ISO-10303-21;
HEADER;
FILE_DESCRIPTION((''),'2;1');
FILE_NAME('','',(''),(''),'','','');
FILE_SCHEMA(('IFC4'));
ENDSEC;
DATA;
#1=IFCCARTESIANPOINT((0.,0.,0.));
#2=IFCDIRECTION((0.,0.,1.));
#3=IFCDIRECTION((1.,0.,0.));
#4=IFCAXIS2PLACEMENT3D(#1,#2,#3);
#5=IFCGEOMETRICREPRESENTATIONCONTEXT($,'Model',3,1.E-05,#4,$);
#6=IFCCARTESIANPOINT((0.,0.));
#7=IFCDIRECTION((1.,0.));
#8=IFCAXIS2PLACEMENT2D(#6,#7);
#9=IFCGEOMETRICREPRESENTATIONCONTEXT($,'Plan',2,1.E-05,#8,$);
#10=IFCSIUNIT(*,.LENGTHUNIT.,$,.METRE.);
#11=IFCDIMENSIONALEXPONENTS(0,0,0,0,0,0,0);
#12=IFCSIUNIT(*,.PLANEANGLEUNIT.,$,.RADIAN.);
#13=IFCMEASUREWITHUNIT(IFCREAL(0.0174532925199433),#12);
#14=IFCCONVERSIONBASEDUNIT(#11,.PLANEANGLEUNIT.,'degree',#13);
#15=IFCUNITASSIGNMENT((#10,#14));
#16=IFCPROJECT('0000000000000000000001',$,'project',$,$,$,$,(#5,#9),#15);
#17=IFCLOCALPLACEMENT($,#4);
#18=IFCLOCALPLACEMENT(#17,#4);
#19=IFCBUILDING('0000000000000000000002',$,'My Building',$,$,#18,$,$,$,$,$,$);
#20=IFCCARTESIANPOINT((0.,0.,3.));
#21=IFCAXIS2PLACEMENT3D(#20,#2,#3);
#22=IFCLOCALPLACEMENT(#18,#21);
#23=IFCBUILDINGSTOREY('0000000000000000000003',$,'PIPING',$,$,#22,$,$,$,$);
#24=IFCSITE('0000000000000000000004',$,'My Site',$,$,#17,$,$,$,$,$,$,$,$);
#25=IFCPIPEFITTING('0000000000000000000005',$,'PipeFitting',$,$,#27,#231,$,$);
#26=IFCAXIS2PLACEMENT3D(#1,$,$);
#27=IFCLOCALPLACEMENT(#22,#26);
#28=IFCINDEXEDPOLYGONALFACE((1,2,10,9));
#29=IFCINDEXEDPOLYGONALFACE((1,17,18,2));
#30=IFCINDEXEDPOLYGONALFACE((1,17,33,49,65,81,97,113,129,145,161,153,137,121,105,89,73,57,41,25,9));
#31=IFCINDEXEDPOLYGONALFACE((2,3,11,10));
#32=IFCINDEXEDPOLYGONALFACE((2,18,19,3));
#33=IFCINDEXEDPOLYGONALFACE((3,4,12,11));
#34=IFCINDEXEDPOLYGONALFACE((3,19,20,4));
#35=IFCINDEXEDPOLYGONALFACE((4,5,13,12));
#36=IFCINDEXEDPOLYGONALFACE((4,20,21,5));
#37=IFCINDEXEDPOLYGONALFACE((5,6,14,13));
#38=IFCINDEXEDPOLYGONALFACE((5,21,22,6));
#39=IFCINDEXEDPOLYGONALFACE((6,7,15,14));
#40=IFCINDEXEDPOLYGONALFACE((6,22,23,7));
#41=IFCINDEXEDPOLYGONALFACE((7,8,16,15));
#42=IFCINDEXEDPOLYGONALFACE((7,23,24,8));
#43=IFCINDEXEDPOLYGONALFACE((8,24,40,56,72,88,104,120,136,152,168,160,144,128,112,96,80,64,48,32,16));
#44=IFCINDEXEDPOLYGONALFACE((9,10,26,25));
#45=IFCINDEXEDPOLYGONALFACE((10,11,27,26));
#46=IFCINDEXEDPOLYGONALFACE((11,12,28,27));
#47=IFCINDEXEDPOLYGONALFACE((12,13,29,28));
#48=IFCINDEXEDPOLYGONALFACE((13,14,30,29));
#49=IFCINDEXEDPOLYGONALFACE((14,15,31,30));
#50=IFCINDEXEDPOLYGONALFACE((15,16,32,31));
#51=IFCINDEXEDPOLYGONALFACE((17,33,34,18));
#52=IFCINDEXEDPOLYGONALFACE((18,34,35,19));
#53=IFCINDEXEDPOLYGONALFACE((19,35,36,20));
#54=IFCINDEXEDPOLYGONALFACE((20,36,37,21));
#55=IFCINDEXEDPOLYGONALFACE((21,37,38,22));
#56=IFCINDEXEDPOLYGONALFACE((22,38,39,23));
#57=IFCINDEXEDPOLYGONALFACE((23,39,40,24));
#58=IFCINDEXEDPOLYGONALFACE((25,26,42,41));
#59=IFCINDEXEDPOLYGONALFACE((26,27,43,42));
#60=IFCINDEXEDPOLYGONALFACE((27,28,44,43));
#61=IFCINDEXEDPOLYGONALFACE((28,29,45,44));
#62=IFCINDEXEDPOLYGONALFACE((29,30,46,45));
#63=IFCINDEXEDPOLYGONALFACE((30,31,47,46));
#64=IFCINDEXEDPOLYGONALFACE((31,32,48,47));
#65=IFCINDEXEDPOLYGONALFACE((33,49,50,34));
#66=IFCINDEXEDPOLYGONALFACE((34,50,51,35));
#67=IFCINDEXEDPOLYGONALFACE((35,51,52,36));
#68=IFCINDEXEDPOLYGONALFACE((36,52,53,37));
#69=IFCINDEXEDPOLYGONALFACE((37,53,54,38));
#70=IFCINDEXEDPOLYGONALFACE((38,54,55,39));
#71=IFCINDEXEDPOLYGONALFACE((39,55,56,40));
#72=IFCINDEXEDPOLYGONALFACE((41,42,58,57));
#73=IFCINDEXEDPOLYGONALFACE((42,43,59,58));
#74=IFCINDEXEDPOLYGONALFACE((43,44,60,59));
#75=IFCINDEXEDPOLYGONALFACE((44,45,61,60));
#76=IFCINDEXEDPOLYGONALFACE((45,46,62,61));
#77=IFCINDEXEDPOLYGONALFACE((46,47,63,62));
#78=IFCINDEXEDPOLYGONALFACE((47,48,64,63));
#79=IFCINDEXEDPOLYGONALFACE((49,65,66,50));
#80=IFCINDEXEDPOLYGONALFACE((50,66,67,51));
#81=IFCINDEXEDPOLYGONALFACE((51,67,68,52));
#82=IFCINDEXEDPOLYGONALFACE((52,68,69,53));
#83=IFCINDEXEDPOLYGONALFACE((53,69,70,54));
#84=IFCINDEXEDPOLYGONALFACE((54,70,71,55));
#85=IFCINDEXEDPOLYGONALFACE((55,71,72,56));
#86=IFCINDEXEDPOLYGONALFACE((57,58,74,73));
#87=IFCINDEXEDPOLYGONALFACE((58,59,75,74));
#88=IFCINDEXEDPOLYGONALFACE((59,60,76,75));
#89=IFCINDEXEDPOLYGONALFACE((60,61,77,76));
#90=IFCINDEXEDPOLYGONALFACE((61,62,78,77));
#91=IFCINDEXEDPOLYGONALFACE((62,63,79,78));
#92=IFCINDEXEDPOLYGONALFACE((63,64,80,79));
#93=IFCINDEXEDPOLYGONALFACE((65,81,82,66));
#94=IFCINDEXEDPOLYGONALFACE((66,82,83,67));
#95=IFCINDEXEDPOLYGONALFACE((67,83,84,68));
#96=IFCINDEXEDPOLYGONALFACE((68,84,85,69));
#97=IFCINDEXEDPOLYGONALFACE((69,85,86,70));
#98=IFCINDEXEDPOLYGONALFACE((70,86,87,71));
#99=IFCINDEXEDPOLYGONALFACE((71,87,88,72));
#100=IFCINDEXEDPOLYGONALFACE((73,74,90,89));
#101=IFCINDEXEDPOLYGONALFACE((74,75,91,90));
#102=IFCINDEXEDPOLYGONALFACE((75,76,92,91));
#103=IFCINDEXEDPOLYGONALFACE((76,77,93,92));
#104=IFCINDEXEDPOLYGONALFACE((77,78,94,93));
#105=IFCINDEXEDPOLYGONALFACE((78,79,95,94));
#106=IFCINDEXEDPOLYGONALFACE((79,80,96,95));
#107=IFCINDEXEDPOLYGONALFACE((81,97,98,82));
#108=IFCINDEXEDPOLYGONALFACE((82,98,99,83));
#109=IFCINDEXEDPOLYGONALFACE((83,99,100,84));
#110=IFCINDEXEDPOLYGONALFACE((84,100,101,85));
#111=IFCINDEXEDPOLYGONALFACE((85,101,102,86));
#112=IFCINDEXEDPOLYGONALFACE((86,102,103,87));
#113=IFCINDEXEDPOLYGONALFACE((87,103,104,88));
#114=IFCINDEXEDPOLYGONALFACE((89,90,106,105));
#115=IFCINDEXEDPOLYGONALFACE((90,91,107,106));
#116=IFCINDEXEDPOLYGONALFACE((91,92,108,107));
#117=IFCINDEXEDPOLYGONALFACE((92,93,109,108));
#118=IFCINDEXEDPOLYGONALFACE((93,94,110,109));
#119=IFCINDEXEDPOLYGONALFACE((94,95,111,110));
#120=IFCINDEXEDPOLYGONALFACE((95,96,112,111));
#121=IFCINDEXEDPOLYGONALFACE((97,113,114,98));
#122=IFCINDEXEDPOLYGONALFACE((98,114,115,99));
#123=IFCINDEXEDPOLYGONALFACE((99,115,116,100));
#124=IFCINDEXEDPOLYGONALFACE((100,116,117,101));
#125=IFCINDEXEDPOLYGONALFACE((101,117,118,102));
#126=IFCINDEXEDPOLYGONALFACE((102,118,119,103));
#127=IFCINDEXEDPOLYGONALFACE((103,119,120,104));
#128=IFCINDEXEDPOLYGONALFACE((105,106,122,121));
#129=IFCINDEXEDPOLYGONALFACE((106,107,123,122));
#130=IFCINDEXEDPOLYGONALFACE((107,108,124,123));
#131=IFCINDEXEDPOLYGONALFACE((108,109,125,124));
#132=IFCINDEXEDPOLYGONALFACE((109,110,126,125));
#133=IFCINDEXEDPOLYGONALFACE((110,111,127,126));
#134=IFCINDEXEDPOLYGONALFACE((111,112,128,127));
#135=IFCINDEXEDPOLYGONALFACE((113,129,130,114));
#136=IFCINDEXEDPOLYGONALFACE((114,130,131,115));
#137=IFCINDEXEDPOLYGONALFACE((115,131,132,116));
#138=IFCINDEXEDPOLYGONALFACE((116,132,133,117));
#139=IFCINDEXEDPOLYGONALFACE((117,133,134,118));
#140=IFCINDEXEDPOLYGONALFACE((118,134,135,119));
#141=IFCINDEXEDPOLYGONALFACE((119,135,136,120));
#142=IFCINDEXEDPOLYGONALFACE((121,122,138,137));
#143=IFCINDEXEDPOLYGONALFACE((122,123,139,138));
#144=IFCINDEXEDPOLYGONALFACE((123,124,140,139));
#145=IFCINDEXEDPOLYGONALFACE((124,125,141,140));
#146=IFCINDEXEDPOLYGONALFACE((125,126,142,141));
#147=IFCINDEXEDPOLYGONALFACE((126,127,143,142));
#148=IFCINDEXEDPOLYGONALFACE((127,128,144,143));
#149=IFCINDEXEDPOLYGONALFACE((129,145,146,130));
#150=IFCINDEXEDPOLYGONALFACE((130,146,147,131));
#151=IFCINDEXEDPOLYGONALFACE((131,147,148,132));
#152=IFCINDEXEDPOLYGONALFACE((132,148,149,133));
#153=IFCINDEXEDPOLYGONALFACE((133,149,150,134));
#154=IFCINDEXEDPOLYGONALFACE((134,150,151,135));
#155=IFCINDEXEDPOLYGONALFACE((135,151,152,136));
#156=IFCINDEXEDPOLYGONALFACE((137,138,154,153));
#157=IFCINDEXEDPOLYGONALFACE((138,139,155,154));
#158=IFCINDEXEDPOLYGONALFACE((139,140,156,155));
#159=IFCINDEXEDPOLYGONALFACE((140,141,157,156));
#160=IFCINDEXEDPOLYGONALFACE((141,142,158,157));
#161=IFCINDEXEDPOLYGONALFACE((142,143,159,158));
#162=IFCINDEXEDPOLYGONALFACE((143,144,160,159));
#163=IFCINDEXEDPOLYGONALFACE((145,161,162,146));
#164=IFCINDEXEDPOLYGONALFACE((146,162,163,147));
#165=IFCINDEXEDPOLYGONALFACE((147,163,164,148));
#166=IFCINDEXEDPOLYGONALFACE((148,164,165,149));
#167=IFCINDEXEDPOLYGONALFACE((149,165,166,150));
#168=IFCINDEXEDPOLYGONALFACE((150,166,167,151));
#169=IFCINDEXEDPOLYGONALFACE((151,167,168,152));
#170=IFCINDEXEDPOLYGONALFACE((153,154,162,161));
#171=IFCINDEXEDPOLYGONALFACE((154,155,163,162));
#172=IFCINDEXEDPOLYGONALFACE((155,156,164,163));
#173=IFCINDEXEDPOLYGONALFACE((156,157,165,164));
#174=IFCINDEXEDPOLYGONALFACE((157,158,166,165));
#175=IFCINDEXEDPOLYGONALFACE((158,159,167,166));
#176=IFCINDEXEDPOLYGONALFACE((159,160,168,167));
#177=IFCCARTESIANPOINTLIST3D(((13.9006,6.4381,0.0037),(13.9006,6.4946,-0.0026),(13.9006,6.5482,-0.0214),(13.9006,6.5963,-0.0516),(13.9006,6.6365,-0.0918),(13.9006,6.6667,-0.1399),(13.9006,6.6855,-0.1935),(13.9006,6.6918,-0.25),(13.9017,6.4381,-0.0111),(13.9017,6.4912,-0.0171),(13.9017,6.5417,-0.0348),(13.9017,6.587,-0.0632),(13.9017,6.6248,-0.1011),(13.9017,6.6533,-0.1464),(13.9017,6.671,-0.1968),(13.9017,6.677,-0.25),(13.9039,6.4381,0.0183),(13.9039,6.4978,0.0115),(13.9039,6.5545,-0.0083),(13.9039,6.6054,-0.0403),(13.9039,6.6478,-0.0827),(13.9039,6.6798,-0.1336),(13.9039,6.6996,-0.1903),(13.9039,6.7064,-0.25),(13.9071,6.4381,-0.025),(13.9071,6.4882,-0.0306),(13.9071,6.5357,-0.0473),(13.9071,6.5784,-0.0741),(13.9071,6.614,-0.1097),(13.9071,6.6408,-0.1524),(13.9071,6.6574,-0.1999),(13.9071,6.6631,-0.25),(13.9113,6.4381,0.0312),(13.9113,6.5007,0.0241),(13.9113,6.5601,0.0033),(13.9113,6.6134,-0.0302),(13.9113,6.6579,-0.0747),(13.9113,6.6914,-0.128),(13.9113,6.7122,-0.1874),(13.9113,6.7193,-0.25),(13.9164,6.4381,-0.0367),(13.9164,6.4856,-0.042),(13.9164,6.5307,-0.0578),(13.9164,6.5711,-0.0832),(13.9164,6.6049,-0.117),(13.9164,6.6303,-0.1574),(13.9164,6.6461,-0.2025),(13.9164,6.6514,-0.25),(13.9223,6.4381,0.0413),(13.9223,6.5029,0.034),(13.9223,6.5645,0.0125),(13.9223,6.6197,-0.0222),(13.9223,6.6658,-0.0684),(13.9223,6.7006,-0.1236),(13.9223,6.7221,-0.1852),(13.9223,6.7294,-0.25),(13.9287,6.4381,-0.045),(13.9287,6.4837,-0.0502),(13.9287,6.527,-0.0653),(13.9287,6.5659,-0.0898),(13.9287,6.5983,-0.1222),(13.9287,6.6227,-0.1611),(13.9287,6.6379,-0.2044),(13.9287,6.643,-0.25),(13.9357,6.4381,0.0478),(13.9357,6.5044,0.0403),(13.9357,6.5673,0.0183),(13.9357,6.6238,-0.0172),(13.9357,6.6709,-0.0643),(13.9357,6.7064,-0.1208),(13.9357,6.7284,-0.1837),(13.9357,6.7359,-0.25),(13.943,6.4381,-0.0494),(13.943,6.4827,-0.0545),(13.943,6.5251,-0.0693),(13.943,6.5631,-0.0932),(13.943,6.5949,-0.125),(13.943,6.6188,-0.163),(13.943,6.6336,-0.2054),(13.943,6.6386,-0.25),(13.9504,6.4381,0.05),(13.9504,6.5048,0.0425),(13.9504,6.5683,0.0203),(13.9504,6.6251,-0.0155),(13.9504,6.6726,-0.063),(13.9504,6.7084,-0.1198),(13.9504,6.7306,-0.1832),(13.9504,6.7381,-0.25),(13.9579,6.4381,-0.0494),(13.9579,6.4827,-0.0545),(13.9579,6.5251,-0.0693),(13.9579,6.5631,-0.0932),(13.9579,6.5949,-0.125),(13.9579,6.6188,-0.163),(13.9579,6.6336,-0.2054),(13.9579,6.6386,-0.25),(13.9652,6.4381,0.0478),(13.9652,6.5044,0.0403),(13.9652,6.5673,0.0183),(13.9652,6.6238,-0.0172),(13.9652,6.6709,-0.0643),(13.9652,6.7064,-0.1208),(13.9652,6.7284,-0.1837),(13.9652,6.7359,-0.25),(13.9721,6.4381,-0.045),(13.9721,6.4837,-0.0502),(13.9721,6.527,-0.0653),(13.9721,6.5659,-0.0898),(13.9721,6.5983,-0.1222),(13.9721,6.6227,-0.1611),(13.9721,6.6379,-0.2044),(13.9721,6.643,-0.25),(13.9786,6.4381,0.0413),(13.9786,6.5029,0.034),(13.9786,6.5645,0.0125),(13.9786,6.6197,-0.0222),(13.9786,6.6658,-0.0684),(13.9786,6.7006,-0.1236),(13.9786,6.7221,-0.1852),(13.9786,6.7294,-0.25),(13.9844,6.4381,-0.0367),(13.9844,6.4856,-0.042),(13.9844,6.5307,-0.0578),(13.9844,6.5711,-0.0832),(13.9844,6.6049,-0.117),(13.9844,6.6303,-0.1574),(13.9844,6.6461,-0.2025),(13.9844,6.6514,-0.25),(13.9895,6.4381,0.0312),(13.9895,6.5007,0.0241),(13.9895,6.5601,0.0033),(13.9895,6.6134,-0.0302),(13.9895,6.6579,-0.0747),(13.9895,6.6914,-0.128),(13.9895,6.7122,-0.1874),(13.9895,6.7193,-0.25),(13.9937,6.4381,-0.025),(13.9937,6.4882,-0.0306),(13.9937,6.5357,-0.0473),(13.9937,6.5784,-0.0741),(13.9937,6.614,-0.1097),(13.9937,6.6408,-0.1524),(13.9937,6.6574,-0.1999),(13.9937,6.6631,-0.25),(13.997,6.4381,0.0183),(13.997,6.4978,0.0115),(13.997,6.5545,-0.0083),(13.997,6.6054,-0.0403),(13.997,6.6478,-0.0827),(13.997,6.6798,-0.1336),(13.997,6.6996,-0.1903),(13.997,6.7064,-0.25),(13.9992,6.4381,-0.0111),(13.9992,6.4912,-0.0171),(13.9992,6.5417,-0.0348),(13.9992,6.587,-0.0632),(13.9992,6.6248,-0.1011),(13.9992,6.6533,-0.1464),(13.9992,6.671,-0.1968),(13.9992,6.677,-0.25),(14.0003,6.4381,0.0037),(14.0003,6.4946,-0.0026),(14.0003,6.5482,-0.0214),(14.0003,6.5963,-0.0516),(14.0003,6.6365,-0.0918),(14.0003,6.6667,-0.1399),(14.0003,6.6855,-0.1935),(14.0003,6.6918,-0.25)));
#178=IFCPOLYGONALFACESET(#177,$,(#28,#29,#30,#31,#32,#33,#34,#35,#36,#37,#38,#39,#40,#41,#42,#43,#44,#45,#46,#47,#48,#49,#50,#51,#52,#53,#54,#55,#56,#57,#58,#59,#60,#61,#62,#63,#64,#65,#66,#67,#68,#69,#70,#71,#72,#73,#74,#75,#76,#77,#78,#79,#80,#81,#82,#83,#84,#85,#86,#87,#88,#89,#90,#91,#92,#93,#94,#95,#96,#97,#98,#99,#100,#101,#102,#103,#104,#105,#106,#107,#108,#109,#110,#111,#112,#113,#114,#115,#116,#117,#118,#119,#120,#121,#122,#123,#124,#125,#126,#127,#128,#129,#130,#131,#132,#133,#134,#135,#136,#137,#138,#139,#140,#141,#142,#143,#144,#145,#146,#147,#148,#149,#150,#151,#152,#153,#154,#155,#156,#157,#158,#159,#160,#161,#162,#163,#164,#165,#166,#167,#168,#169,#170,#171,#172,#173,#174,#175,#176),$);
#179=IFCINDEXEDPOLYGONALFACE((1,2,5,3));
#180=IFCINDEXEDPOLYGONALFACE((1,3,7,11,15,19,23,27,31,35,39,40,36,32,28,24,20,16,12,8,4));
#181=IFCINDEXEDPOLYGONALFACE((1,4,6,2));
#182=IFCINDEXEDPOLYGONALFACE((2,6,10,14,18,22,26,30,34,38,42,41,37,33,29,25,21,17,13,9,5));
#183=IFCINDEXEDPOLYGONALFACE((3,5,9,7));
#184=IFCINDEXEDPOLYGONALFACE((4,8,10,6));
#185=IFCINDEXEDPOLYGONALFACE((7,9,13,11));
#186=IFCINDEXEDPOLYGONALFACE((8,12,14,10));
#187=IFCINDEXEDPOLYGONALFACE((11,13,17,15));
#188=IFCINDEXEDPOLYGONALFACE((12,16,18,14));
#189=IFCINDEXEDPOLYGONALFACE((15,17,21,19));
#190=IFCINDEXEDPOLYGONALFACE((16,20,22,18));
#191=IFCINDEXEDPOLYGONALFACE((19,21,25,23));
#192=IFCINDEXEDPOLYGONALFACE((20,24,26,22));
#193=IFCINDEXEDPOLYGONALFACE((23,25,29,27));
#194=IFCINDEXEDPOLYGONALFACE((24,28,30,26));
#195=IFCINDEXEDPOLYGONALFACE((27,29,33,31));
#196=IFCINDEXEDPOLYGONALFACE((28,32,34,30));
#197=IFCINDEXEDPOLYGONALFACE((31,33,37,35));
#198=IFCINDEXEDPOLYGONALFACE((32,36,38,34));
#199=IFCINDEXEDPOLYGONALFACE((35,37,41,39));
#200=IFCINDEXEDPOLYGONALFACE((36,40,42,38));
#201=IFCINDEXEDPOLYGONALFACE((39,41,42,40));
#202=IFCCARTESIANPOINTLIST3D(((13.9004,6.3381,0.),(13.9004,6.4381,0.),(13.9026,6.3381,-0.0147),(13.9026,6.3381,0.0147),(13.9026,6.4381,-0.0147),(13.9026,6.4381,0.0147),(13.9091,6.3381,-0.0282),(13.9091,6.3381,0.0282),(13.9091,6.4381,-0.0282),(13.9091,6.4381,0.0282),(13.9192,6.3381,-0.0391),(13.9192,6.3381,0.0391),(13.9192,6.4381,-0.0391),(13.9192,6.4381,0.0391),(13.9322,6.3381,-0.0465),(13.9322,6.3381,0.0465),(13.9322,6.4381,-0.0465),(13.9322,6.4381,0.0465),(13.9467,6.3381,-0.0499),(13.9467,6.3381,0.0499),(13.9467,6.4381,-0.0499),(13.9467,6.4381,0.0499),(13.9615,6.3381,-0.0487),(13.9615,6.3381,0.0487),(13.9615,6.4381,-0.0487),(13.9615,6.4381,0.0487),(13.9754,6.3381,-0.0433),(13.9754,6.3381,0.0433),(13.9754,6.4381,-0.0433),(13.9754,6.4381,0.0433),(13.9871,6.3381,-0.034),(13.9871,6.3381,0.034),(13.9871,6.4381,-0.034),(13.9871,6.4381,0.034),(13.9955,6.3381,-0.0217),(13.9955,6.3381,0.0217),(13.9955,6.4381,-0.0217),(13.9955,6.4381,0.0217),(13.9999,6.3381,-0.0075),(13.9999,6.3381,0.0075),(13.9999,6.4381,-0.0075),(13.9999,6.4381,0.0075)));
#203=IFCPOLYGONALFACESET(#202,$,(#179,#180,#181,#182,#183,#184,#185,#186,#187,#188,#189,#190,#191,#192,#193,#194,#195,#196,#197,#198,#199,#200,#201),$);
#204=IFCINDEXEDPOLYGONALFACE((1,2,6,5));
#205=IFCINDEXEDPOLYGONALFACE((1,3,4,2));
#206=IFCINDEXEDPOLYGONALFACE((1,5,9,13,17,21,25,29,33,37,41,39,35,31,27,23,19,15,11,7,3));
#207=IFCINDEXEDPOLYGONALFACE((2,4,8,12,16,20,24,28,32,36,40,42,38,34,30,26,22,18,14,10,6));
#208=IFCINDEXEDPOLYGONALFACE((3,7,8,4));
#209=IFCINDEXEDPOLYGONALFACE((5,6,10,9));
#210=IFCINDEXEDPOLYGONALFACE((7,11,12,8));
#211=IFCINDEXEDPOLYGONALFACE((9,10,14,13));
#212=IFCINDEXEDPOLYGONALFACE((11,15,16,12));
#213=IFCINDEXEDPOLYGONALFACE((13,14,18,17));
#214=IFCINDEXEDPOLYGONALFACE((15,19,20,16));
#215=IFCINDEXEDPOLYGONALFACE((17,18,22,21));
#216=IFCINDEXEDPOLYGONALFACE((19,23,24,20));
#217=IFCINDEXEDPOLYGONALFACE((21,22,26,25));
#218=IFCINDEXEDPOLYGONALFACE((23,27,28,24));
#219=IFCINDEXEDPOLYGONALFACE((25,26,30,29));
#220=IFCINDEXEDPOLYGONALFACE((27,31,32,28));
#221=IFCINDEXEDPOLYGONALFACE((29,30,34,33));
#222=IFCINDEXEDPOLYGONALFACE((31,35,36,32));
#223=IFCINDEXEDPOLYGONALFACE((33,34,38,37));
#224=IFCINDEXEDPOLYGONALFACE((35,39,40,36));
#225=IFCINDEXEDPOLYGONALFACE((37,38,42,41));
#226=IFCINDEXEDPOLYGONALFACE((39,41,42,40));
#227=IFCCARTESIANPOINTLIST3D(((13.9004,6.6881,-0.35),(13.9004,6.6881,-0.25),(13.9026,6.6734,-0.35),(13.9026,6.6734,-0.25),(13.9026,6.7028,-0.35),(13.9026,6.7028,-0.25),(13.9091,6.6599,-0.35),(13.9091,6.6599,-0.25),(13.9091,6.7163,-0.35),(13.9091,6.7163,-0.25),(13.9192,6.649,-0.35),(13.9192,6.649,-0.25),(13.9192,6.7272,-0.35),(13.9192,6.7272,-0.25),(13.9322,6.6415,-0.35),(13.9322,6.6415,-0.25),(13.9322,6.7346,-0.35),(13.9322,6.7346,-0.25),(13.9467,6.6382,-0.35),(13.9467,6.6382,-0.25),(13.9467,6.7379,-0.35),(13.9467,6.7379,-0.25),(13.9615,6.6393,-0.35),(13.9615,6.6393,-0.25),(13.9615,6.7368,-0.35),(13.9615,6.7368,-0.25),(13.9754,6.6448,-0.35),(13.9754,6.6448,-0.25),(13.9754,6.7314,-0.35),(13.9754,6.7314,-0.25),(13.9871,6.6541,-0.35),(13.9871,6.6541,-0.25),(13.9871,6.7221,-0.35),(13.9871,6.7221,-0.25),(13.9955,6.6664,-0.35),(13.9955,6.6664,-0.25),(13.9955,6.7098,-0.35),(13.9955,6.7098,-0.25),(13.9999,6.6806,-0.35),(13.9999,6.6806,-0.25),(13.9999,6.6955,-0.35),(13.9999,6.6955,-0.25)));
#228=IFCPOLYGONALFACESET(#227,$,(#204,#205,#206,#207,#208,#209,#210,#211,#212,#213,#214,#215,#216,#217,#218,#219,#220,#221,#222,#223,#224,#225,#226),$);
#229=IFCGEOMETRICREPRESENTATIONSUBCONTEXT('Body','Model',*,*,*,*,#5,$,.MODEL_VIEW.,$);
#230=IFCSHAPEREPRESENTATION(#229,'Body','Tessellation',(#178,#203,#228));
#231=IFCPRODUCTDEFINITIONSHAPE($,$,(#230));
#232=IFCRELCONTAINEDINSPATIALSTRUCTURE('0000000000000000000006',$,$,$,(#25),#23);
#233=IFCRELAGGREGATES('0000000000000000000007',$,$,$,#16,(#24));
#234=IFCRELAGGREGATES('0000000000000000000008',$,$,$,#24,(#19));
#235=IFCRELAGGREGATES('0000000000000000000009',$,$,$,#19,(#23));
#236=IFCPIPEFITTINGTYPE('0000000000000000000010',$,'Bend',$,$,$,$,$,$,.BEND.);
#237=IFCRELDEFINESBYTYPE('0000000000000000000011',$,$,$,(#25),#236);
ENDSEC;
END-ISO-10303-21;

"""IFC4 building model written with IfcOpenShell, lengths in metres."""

from ifc_helpers import new_model, entity, si_unit, converted_unit, frame, origin_with_axes, origin_2d_with_axis, place, context, subcontext, project, spatial, circle, extrude, source, transform, mapped, type_object, type_shapes, element, save


model = new_model("IFC4")

# Units and contexts
model_context = context("Model", 3, precision=1e-05, world=origin_with_axes())
plan_context = context("Plan", 2, precision=1e-05, world=origin_2d_with_axis())
body_context = subcontext(model_context, "Body", "Model", "MODEL_VIEW")
ifc_project = project(units=[si_unit("LENGTHUNIT", "METRE"), converted_unit("PLANEANGLEUNIT", "degree", entity("IfcReal", 0.0174532925199433), si_unit("PLANEANGLEUNIT", "RADIAN"), dimensions=[0, 0, 0, 0, 0, 0, 0])], contexts=[model_context, plan_context])

# Site, building, storey
site_placement = place(None, origin_with_axes())
site = spatial("IfcSite", under=ifc_project, at=site_placement, Name="My Site")
building_placement = place(site_placement, origin_with_axes())
building = spatial("IfcBuilding", under=site, at=building_placement, Name="My Building")
storey_placement = place(building_placement, frame((0.0, 0.0, 3.0), z_axis=(0.0, 0.0, 1.0), x_axis=(1.0, 0.0, 0.0)))
storey = spatial("IfcBuildingStorey", under=building, at=storey_placement, Name="PIPING")

# Pipe fitting
pipe_fitting_type = type_object("IfcPipeFittingType", Name="Bend", PredefinedType="BEND")
shared_shape = source(origin_with_axes(), body_context, "Body", "SolidModel", [
    entity("IfcSweptDiskSolid", entity("IfcIndexedPolyCurve", entity("IfcCartesianPointList3D", [[0.0, 0.0, 0.1], [0.0, -0.0732, 0.2768], [0.0, -0.25, 0.35]]), [entity("IfcArcIndex", [1, 2, 3])]), 0.05),
    extrude(circle(Radius=0.05), origin_with_axes(), (0.0, 0.0, 1.0), 0.1),
    extrude(circle(Radius=0.05), frame((0.0, -0.25, 0.35), z_axis=(0.0, -1.0, 0.0), x_axis=(1.0, 0.0, 0.0)), (0.0, 0.0, 1.0), 0.1),
])
type_shapes(pipe_fitting_type, [shared_shape])
for number, where, z_axis, x_axis, name in (
    (1, (13.9504, 6.3381, 0.0), (0.0, 1.0, 0.0), (-1.0, 0.0, 0.0), "PipeFitting"),
):
    element("IfcPipeFitting", number, at=place(storey_placement, frame(where, z_axis=z_axis, x_axis=x_axis)), inside=storey, type_object=pipe_fitting_type, Name=name, context=body_context, shape_type="MappedRepresentation", body=[
        mapped(shared_shape, transform((0.0, 0.0, 0.0), x_axis=(1.0, 0.0, 0.0), y_axis=(0.0, 1.0, 0.0), z_axis=(0.0, 0.0, 1.0), scale=1.0)),
    ])

save(model, "model.ifc")
